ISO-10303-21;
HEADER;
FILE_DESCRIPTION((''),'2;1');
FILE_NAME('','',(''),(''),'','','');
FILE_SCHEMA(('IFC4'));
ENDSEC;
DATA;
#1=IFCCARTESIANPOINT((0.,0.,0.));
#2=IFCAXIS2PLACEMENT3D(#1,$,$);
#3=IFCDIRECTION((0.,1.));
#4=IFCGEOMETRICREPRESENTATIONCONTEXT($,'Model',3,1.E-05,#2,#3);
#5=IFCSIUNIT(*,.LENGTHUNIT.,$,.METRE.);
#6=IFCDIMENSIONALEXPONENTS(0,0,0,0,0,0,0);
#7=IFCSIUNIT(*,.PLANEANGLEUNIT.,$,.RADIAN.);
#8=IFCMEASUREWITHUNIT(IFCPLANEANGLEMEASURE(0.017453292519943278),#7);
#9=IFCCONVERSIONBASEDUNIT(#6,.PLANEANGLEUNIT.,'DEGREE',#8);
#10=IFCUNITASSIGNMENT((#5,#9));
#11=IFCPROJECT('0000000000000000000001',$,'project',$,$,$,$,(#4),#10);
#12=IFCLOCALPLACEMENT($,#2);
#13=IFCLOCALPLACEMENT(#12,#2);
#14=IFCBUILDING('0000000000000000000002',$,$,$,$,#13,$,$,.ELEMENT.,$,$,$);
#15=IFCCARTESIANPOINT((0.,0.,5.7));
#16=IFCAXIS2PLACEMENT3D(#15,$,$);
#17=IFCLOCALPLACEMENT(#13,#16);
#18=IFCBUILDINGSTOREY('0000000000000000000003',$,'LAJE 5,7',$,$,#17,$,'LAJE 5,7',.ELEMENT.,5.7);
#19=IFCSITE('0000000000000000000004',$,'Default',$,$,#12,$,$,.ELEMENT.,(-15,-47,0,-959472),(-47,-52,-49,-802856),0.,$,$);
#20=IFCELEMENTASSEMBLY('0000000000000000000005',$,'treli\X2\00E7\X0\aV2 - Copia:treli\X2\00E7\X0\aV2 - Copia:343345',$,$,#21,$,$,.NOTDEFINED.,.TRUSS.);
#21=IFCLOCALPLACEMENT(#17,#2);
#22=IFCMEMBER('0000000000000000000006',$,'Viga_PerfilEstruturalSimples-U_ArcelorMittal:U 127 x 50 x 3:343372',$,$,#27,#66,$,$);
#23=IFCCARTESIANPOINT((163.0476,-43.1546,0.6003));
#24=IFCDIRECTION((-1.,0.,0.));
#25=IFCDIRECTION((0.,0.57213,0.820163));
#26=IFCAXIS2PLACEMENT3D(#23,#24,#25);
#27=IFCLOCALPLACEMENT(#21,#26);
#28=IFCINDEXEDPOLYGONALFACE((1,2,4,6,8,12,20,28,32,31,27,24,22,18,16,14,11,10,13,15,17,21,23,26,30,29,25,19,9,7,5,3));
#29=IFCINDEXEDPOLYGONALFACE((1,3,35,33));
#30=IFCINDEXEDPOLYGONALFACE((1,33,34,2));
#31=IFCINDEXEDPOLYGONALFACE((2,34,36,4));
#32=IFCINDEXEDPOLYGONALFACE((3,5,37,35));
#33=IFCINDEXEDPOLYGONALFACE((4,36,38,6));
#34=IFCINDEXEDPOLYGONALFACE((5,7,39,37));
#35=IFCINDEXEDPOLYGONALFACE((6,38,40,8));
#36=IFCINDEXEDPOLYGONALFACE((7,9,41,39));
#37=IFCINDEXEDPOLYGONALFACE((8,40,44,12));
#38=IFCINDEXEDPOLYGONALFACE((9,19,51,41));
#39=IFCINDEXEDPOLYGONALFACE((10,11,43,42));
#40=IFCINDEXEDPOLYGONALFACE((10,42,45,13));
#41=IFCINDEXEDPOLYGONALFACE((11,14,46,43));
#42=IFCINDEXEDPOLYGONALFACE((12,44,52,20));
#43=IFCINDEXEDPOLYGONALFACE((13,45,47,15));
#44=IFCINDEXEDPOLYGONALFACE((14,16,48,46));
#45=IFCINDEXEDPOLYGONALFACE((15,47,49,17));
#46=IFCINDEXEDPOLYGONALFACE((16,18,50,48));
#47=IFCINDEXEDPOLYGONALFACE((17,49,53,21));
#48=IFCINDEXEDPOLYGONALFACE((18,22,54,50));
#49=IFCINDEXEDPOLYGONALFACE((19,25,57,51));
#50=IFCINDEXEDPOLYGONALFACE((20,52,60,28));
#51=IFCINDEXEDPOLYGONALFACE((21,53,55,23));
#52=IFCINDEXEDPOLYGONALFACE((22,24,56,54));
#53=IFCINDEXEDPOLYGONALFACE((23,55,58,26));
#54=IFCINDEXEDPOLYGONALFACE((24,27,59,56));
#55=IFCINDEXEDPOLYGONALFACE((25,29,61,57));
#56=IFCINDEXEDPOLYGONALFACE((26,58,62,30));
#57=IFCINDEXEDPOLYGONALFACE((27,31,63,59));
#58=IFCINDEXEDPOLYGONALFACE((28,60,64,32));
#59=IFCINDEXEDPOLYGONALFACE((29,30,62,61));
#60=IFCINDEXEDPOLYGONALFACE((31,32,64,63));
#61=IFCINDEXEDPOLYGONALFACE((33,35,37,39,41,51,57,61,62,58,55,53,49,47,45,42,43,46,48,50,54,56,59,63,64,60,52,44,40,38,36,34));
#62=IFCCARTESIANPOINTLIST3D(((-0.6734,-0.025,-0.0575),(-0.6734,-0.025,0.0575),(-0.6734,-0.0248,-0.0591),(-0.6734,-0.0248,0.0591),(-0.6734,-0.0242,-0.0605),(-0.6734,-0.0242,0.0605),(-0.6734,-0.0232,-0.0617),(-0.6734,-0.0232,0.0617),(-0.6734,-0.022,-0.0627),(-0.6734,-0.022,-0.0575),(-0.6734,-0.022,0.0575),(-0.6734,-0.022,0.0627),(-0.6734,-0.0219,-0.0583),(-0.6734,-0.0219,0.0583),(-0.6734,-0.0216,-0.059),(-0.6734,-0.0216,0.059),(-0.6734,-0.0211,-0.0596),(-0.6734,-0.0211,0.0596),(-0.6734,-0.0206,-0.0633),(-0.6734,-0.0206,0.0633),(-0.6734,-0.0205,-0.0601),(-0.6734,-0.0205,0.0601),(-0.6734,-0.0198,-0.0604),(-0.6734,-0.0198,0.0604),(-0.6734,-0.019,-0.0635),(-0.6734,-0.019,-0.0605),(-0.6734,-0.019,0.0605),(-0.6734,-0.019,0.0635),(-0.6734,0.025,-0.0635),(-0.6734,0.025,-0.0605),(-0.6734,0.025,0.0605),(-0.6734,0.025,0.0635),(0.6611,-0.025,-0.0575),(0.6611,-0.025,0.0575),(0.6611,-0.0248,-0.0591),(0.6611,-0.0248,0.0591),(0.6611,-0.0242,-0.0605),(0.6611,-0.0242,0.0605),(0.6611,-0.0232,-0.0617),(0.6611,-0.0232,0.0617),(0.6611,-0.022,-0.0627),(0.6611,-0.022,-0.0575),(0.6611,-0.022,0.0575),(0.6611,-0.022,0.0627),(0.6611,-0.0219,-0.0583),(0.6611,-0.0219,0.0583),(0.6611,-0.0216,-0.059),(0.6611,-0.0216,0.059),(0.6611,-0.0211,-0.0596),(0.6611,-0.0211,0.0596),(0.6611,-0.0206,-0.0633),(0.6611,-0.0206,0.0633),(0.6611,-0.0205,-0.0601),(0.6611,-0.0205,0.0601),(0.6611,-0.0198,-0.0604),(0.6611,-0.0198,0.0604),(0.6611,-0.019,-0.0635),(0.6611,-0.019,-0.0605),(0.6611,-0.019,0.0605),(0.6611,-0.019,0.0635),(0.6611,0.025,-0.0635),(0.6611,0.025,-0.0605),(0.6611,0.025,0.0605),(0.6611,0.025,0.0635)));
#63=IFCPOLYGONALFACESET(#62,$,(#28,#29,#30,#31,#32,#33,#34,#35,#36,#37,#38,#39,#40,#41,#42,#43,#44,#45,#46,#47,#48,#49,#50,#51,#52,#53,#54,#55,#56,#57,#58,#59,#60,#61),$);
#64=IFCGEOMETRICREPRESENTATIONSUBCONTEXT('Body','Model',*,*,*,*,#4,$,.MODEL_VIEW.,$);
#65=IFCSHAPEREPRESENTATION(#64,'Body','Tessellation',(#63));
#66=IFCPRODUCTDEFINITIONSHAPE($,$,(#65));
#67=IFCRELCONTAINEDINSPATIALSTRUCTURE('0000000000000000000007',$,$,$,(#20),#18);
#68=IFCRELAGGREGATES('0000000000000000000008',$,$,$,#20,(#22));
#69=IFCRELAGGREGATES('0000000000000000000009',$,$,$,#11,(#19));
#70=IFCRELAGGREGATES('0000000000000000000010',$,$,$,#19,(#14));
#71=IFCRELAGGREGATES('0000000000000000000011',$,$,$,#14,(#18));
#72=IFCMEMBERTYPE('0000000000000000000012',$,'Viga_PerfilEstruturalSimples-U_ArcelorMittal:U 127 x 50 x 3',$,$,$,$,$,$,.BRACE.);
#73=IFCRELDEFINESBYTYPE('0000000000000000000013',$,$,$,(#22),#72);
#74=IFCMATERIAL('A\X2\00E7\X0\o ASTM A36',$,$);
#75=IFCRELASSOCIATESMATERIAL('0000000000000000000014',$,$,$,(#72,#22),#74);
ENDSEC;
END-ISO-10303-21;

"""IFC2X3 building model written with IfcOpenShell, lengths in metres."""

from ifc_helpers import new_model, entity, si_unit, converted_unit, direction, frame, frame_2d, origin, place, context, subcontext, project, spatial, polyline, circle_curve, parameter, trimmed, segment, composite_curve, outline, extrude, source, transform, mapped, material, type_object, type_shapes, element, aggregate, save


model = new_model("IFC2X3")

# Units and contexts
model_context = context("Model", 3, precision=1e-05, world=origin(), true_north=direction((0.0, 1.0)))
body_context = subcontext(model_context, "Body", "Model", "MODEL_VIEW")
ifc_project = project(units=[si_unit("LENGTHUNIT", "METRE"), converted_unit("PLANEANGLEUNIT", "DEGREE", entity("IfcPlaneAngleMeasure", 0.017453292519943278), si_unit("PLANEANGLEUNIT", "RADIAN"), dimensions=[0, 0, 0, 0, 0, 0, 0])], contexts=[model_context])

# Site, building, storey
site_placement = place(None, origin())
site = spatial("IfcSite", under=ifc_project, at=site_placement, Name="Default", CompositionType="ELEMENT", RefLatitude=(-15, -47, 0, -959472), RefLongitude=(-47, -52, -49, -802856), RefElevation=0.0)
building_placement = place(site_placement, origin())
building = spatial("IfcBuilding", under=site, at=building_placement, CompositionType="ELEMENT")
storey_placement = place(building_placement, frame((0.0, 0.0, 5.7)))
storey = spatial("IfcBuildingStorey", under=building, at=storey_placement, Name="LAJE 5,7", LongName="LAJE 5,7", CompositionType="ELEMENT", Elevation=5.7)

# Element assembly
assembly_1_placement = place(storey_placement, origin())
assembly_1 = element("IfcElementAssembly", 1, at=assembly_1_placement, inside=storey, Name="treliçaV2 - Copia:treliçaV2 - Copia:343345", AssemblyPlace="NOTDEFINED", PredefinedType="TRUSS")
ifc_material = material(Name="Aço ASTM A36")

# Member
member_type_1 = type_object("IfcMemberType", Name="Viga_PerfilEstruturalSimples-U_ArcelorMittal:U 127 x 50 x 3", PredefinedType="BRACE", material=ifc_material)
shared_shape_1 = source(origin(), body_context, "Body", "SweptSolid", [
    extrude(outline(composite_curve([segment(polyline([(-0.0575, -0.0192), (0.0575, -0.0192)]), True, "CONTINUOUS"), segment(trimmed(circle_curve(frame_2d((0.0575, -0.0132), x_axis=(0.0, 1.0)), 0.006), [parameter(180.0)], [parameter(270.0)], True, "PARAMETER"), True, "CONTINUOUS"), segment(polyline([(0.0635, -0.0132), (0.0635, 0.0308)]), True, "CONTINUOUS"), segment(polyline([(0.0635, 0.0308), (0.0605, 0.0308)]), True, "CONTINUOUS"), segment(polyline([(0.0605, 0.0308), (0.0605, -0.0132)]), True, "CONTINUOUS"), segment(trimmed(circle_curve(frame_2d((0.0575, -0.0132), x_axis=(0.0, 1.0)), 0.003), [parameter(180.0)], [parameter(270.0)], True, "PARAMETER"), False, "CONTINUOUS"), segment(polyline([(0.0575, -0.0162), (-0.0575, -0.0162)]), True, "CONTINUOUS"), segment(trimmed(circle_curve(frame_2d((-0.0575, -0.0132), x_axis=(0.0, 1.0)), 0.003), [parameter(90.0)], [parameter(180.0)], True, "PARAMETER"), False, "CONTINUOUS"), segment(polyline([(-0.0605, -0.0132), (-0.0605, 0.0308)]), True, "CONTINUOUS"), segment(polyline([(-0.0605, 0.0308), (-0.0635, 0.0308)]), True, "CONTINUOUS"), segment(polyline([(-0.0635, 0.0308), (-0.0635, -0.0132)]), True, "CONTINUOUS"), segment(trimmed(circle_curve(frame_2d((-0.0575, -0.0132), x_axis=(0.0, 1.0)), 0.006), [parameter(90.0)], [parameter(180.0)], True, "PARAMETER"), True, "CONTINUOUS")], self_intersect=False)), frame((-0.6734, -0.0058, 0.0), z_axis=(1.0, 0.0, 0.0), x_axis=(0.0, 0.0, -1.0)), (0.0, 0.0, 1.0), 1.3345),
])
type_shapes(member_type_1, [shared_shape_1])
member_1_placement = place(assembly_1_placement, frame((163.0476, -43.1546, 0.6003), z_axis=(-1.0, 0.0, 0.0), x_axis=(0.0, 0.57213, 0.820163)))
member_1 = element("IfcMember", 2, at=member_1_placement, type_object=member_type_1, material=ifc_material, Name="Viga_PerfilEstruturalSimples-U_ArcelorMittal:U 127 x 50 x 3:343372", context=body_context, shape_type="MappedRepresentation", body=[
    mapped(shared_shape_1, transform((0.0, 0.0, 0.0), scale=1.0)),
])
aggregate(assembly_1, [member_1])

save(model, "model.ifc")
